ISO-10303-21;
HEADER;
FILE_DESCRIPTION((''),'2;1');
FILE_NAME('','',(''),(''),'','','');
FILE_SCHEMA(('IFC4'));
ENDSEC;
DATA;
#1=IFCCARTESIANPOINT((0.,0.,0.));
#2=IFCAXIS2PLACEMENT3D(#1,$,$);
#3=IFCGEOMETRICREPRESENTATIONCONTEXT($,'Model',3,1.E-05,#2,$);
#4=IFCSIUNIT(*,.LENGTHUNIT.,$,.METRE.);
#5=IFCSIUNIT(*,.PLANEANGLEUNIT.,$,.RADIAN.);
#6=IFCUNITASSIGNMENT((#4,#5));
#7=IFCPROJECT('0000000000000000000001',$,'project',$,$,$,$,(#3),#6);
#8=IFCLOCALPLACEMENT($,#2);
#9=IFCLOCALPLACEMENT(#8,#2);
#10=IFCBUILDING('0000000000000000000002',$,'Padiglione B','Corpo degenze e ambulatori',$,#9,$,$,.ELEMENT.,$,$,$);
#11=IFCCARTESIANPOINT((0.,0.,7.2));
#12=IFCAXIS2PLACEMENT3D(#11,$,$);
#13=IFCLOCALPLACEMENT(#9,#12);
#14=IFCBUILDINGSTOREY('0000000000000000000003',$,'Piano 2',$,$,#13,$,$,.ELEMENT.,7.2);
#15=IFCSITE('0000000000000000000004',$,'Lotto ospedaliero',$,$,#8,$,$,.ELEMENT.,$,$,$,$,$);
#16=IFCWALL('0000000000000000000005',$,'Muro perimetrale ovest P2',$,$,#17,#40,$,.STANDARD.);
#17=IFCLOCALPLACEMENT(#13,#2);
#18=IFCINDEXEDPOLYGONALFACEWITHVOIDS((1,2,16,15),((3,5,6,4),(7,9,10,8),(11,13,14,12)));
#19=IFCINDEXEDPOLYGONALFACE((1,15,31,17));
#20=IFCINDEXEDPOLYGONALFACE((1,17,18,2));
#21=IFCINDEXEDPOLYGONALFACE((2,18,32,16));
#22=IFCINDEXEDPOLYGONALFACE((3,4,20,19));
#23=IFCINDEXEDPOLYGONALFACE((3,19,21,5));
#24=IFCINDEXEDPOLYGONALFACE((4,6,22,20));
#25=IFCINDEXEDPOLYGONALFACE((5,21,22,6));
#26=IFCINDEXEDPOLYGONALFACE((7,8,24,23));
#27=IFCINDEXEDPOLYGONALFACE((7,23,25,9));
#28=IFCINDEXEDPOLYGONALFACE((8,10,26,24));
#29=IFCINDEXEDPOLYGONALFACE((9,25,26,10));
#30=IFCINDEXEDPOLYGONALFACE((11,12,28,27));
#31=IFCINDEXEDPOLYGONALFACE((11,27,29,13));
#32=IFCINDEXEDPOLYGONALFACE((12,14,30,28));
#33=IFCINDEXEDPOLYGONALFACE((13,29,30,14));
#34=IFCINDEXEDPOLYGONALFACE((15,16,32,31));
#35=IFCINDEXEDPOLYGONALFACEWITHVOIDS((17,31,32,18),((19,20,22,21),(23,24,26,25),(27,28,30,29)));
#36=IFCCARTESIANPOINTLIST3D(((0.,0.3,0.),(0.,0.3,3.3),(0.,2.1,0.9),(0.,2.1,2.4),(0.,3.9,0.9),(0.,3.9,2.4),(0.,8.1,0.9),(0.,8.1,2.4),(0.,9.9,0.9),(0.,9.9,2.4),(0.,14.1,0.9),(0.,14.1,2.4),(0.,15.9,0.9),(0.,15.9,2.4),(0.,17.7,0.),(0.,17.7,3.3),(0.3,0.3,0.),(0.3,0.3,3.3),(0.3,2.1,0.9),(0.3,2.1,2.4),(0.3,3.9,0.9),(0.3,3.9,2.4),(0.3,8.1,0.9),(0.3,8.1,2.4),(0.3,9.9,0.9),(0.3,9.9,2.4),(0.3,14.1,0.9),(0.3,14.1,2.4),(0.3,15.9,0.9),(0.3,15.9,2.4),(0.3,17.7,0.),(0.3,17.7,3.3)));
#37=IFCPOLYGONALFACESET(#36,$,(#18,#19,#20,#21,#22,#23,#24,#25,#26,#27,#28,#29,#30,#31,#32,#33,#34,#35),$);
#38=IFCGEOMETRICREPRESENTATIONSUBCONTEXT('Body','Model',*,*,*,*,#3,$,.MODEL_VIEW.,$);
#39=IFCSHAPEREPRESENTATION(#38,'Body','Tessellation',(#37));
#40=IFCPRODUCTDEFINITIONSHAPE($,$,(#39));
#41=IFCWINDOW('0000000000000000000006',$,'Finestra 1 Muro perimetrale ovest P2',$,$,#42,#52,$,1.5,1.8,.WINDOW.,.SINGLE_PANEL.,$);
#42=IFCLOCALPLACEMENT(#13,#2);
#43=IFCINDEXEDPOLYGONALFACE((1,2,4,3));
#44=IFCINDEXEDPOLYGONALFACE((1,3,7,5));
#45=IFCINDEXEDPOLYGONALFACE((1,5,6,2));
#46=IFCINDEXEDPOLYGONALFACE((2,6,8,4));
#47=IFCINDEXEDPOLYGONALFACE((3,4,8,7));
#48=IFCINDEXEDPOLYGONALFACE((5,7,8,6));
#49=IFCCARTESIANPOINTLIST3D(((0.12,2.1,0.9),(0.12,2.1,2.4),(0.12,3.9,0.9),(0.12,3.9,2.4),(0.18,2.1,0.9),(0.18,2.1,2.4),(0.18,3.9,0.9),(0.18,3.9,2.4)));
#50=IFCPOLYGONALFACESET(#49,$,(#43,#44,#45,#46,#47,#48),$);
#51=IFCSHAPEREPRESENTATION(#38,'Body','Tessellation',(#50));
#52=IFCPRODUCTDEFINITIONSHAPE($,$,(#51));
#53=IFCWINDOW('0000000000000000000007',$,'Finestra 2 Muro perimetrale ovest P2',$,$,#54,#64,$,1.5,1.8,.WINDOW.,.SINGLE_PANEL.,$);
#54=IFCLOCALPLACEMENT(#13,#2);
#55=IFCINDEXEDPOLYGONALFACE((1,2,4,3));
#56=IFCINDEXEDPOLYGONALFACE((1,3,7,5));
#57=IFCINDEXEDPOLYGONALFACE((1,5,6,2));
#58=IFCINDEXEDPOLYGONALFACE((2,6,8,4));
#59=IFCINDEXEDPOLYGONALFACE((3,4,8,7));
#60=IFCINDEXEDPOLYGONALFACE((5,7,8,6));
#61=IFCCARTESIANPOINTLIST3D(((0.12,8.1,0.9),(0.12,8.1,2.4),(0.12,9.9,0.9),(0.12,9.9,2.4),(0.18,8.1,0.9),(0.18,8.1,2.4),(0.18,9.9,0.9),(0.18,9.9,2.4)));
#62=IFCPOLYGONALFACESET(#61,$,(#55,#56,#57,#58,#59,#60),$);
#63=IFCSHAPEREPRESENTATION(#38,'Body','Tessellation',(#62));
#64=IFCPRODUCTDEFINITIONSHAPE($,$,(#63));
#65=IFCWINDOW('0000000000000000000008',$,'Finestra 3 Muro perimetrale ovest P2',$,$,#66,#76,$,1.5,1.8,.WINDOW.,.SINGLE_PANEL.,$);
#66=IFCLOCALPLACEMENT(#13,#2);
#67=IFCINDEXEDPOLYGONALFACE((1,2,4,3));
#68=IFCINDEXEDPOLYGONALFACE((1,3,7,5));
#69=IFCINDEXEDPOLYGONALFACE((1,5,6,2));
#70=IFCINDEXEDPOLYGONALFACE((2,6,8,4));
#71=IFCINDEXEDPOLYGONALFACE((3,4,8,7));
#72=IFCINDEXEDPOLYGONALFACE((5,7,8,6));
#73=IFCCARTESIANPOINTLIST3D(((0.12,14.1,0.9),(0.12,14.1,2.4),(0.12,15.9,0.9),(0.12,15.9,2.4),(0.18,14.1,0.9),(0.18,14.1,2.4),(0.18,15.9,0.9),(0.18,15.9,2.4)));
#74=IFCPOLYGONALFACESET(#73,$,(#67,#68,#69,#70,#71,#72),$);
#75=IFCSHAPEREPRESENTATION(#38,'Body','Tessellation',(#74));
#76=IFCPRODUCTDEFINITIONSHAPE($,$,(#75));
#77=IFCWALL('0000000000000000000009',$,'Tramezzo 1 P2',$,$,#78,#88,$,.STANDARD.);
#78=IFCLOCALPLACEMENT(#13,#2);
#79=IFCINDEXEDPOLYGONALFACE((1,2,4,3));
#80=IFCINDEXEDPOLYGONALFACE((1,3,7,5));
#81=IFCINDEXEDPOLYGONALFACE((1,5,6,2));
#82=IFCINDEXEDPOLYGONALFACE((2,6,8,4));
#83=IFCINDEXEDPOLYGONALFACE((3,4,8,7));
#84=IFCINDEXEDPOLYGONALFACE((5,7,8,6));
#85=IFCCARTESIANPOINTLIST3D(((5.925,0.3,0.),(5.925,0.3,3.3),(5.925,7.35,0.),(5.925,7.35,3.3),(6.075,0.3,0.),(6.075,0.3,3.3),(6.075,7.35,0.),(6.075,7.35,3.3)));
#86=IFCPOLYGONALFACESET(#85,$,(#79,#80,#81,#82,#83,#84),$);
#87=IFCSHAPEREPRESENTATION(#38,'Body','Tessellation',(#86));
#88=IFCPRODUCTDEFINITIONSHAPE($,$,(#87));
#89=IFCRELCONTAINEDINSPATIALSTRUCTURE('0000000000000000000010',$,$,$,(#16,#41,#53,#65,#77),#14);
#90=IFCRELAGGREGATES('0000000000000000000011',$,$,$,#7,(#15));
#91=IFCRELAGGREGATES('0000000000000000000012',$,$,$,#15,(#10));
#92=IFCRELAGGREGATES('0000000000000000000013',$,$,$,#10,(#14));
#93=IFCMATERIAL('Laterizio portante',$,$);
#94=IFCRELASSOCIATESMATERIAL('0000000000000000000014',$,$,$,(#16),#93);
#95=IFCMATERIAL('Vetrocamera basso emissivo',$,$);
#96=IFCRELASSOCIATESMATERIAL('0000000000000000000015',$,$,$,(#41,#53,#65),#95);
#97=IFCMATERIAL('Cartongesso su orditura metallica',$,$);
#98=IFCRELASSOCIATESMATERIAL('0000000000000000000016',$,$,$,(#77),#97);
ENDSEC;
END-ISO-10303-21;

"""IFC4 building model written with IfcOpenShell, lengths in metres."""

from ifc_helpers import new_model, si_unit, frame, frame_2d, origin, place, context, subcontext, project, spatial, rectangle, extrude, material, element, fill, save


model = new_model("IFC4")

# Units and contexts
model_context = context("Model", 3, precision=1e-05, world=origin())
body_context = subcontext(model_context, "Body", "Model", "MODEL_VIEW")
ifc_project = project(units=[si_unit("LENGTHUNIT", "METRE"), si_unit("PLANEANGLEUNIT", "RADIAN")], contexts=[model_context])

# Site, building, storey
site_placement = place(None, origin())
site = spatial("IfcSite", under=ifc_project, at=site_placement, Name="Lotto ospedaliero", CompositionType="ELEMENT")
building_placement = place(site_placement, origin())
building = spatial("IfcBuilding", under=site, at=building_placement, Name="Padiglione B", Description="Corpo degenze e ambulatori", CompositionType="ELEMENT")
storey_placement = place(building_placement, frame((0.0, 0.0, 7.2)))
storey = spatial("IfcBuildingStorey", under=building, at=storey_placement, Name="Piano 2", CompositionType="ELEMENT", Elevation=7.2)

# Wall, openings, windows
ifc_material_1 = material(Name="Laterizio portante")
ifc_material_2 = material(Name="Vetrocamera basso emissivo")
wall_1_placement = place(storey_placement, frame((0.0, 0.3, 0.0)))
wall_1 = element("IfcWall", 1, at=wall_1_placement, inside=storey, material=ifc_material_1, Name="Muro perimetrale ovest P2", PredefinedType="STANDARD", context=body_context, shape_type="SweptSolid", body=[
    extrude(rectangle(XDim=0.3, YDim=17.4, at=frame_2d((0.15, 8.7))), origin(), (0.0, 0.0, 1.0), 3.3),
])
opening_1_placement = place(wall_1_placement, frame((-0.1, 1.8, 0.9)))
opening_1 = element("IfcOpeningElement", 2, at=opening_1_placement, cuts=wall_1, PredefinedType="OPENING", context=body_context, shape_type="SweptSolid", body=[
    extrude(rectangle(XDim=0.5, YDim=1.8, at=frame_2d((0.25, 0.9))), origin(), (0.0, 0.0, 1.0), 1.5),
])
opening_2_placement = place(wall_1_placement, frame((-0.1, 7.8, 0.9)))
opening_2 = element("IfcOpeningElement", 3, at=opening_2_placement, cuts=wall_1, PredefinedType="OPENING", context=body_context, shape_type="SweptSolid", body=[
    extrude(rectangle(XDim=0.5, YDim=1.8, at=frame_2d((0.25, 0.9))), origin(), (0.0, 0.0, 1.0), 1.5),
])
opening_3_placement = place(wall_1_placement, frame((-0.1, 13.8, 0.9)))
opening_3 = element("IfcOpeningElement", 4, at=opening_3_placement, cuts=wall_1, PredefinedType="OPENING", context=body_context, shape_type="SweptSolid", body=[
    extrude(rectangle(XDim=0.5, YDim=1.8, at=frame_2d((0.25, 0.9))), origin(), (0.0, 0.0, 1.0), 1.5),
])
window_1_placement = place(wall_1_placement, frame((0.12, 1.8, 0.9)))
window_1 = element("IfcWindow", 5, at=window_1_placement, inside=storey, material=ifc_material_2, Name="Finestra 1 Muro perimetrale ovest P2", OverallHeight=1.5, OverallWidth=1.8, PartitioningType="SINGLE_PANEL", PredefinedType="WINDOW", context=body_context, shape_type="SweptSolid", body=[
    extrude(rectangle(XDim=0.06, YDim=1.8, at=frame_2d((0.03, 0.9))), origin(), (0.0, 0.0, 1.0), 1.5),
])
fill(opening_1, window_1)
window_2_placement = place(wall_1_placement, frame((0.12, 7.8, 0.9)))
window_2 = element("IfcWindow", 6, at=window_2_placement, inside=storey, material=ifc_material_2, Name="Finestra 2 Muro perimetrale ovest P2", OverallHeight=1.5, OverallWidth=1.8, PartitioningType="SINGLE_PANEL", PredefinedType="WINDOW", context=body_context, shape_type="SweptSolid", body=[
    extrude(rectangle(XDim=0.06, YDim=1.8, at=frame_2d((0.03, 0.9))), origin(), (0.0, 0.0, 1.0), 1.5),
])
fill(opening_2, window_2)
window_3_placement = place(wall_1_placement, frame((0.12, 13.8, 0.9)))
window_3 = element("IfcWindow", 7, at=window_3_placement, inside=storey, material=ifc_material_2, Name="Finestra 3 Muro perimetrale ovest P2", OverallHeight=1.5, OverallWidth=1.8, PartitioningType="SINGLE_PANEL", PredefinedType="WINDOW", context=body_context, shape_type="SweptSolid", body=[
    extrude(rectangle(XDim=0.06, YDim=1.8, at=frame_2d((0.03, 0.9))), origin(), (0.0, 0.0, 1.0), 1.5),
])
fill(opening_3, window_3)

# Wall
ifc_material_3 = material(Name="Cartongesso su orditura metallica")
wall_2_placement = place(storey_placement, frame((5.925, 0.3, 0.0)))
element("IfcWall", 8, at=wall_2_placement, inside=storey, material=ifc_material_3, Name="Tramezzo 1 P2", PredefinedType="STANDARD", context=body_context, shape_type="SweptSolid", body=[
    extrude(rectangle(XDim=0.15, YDim=7.05, at=frame_2d((0.075, 3.525))), origin(), (0.0, 0.0, 1.0), 3.3),
])

save(model, "model.ifc")
